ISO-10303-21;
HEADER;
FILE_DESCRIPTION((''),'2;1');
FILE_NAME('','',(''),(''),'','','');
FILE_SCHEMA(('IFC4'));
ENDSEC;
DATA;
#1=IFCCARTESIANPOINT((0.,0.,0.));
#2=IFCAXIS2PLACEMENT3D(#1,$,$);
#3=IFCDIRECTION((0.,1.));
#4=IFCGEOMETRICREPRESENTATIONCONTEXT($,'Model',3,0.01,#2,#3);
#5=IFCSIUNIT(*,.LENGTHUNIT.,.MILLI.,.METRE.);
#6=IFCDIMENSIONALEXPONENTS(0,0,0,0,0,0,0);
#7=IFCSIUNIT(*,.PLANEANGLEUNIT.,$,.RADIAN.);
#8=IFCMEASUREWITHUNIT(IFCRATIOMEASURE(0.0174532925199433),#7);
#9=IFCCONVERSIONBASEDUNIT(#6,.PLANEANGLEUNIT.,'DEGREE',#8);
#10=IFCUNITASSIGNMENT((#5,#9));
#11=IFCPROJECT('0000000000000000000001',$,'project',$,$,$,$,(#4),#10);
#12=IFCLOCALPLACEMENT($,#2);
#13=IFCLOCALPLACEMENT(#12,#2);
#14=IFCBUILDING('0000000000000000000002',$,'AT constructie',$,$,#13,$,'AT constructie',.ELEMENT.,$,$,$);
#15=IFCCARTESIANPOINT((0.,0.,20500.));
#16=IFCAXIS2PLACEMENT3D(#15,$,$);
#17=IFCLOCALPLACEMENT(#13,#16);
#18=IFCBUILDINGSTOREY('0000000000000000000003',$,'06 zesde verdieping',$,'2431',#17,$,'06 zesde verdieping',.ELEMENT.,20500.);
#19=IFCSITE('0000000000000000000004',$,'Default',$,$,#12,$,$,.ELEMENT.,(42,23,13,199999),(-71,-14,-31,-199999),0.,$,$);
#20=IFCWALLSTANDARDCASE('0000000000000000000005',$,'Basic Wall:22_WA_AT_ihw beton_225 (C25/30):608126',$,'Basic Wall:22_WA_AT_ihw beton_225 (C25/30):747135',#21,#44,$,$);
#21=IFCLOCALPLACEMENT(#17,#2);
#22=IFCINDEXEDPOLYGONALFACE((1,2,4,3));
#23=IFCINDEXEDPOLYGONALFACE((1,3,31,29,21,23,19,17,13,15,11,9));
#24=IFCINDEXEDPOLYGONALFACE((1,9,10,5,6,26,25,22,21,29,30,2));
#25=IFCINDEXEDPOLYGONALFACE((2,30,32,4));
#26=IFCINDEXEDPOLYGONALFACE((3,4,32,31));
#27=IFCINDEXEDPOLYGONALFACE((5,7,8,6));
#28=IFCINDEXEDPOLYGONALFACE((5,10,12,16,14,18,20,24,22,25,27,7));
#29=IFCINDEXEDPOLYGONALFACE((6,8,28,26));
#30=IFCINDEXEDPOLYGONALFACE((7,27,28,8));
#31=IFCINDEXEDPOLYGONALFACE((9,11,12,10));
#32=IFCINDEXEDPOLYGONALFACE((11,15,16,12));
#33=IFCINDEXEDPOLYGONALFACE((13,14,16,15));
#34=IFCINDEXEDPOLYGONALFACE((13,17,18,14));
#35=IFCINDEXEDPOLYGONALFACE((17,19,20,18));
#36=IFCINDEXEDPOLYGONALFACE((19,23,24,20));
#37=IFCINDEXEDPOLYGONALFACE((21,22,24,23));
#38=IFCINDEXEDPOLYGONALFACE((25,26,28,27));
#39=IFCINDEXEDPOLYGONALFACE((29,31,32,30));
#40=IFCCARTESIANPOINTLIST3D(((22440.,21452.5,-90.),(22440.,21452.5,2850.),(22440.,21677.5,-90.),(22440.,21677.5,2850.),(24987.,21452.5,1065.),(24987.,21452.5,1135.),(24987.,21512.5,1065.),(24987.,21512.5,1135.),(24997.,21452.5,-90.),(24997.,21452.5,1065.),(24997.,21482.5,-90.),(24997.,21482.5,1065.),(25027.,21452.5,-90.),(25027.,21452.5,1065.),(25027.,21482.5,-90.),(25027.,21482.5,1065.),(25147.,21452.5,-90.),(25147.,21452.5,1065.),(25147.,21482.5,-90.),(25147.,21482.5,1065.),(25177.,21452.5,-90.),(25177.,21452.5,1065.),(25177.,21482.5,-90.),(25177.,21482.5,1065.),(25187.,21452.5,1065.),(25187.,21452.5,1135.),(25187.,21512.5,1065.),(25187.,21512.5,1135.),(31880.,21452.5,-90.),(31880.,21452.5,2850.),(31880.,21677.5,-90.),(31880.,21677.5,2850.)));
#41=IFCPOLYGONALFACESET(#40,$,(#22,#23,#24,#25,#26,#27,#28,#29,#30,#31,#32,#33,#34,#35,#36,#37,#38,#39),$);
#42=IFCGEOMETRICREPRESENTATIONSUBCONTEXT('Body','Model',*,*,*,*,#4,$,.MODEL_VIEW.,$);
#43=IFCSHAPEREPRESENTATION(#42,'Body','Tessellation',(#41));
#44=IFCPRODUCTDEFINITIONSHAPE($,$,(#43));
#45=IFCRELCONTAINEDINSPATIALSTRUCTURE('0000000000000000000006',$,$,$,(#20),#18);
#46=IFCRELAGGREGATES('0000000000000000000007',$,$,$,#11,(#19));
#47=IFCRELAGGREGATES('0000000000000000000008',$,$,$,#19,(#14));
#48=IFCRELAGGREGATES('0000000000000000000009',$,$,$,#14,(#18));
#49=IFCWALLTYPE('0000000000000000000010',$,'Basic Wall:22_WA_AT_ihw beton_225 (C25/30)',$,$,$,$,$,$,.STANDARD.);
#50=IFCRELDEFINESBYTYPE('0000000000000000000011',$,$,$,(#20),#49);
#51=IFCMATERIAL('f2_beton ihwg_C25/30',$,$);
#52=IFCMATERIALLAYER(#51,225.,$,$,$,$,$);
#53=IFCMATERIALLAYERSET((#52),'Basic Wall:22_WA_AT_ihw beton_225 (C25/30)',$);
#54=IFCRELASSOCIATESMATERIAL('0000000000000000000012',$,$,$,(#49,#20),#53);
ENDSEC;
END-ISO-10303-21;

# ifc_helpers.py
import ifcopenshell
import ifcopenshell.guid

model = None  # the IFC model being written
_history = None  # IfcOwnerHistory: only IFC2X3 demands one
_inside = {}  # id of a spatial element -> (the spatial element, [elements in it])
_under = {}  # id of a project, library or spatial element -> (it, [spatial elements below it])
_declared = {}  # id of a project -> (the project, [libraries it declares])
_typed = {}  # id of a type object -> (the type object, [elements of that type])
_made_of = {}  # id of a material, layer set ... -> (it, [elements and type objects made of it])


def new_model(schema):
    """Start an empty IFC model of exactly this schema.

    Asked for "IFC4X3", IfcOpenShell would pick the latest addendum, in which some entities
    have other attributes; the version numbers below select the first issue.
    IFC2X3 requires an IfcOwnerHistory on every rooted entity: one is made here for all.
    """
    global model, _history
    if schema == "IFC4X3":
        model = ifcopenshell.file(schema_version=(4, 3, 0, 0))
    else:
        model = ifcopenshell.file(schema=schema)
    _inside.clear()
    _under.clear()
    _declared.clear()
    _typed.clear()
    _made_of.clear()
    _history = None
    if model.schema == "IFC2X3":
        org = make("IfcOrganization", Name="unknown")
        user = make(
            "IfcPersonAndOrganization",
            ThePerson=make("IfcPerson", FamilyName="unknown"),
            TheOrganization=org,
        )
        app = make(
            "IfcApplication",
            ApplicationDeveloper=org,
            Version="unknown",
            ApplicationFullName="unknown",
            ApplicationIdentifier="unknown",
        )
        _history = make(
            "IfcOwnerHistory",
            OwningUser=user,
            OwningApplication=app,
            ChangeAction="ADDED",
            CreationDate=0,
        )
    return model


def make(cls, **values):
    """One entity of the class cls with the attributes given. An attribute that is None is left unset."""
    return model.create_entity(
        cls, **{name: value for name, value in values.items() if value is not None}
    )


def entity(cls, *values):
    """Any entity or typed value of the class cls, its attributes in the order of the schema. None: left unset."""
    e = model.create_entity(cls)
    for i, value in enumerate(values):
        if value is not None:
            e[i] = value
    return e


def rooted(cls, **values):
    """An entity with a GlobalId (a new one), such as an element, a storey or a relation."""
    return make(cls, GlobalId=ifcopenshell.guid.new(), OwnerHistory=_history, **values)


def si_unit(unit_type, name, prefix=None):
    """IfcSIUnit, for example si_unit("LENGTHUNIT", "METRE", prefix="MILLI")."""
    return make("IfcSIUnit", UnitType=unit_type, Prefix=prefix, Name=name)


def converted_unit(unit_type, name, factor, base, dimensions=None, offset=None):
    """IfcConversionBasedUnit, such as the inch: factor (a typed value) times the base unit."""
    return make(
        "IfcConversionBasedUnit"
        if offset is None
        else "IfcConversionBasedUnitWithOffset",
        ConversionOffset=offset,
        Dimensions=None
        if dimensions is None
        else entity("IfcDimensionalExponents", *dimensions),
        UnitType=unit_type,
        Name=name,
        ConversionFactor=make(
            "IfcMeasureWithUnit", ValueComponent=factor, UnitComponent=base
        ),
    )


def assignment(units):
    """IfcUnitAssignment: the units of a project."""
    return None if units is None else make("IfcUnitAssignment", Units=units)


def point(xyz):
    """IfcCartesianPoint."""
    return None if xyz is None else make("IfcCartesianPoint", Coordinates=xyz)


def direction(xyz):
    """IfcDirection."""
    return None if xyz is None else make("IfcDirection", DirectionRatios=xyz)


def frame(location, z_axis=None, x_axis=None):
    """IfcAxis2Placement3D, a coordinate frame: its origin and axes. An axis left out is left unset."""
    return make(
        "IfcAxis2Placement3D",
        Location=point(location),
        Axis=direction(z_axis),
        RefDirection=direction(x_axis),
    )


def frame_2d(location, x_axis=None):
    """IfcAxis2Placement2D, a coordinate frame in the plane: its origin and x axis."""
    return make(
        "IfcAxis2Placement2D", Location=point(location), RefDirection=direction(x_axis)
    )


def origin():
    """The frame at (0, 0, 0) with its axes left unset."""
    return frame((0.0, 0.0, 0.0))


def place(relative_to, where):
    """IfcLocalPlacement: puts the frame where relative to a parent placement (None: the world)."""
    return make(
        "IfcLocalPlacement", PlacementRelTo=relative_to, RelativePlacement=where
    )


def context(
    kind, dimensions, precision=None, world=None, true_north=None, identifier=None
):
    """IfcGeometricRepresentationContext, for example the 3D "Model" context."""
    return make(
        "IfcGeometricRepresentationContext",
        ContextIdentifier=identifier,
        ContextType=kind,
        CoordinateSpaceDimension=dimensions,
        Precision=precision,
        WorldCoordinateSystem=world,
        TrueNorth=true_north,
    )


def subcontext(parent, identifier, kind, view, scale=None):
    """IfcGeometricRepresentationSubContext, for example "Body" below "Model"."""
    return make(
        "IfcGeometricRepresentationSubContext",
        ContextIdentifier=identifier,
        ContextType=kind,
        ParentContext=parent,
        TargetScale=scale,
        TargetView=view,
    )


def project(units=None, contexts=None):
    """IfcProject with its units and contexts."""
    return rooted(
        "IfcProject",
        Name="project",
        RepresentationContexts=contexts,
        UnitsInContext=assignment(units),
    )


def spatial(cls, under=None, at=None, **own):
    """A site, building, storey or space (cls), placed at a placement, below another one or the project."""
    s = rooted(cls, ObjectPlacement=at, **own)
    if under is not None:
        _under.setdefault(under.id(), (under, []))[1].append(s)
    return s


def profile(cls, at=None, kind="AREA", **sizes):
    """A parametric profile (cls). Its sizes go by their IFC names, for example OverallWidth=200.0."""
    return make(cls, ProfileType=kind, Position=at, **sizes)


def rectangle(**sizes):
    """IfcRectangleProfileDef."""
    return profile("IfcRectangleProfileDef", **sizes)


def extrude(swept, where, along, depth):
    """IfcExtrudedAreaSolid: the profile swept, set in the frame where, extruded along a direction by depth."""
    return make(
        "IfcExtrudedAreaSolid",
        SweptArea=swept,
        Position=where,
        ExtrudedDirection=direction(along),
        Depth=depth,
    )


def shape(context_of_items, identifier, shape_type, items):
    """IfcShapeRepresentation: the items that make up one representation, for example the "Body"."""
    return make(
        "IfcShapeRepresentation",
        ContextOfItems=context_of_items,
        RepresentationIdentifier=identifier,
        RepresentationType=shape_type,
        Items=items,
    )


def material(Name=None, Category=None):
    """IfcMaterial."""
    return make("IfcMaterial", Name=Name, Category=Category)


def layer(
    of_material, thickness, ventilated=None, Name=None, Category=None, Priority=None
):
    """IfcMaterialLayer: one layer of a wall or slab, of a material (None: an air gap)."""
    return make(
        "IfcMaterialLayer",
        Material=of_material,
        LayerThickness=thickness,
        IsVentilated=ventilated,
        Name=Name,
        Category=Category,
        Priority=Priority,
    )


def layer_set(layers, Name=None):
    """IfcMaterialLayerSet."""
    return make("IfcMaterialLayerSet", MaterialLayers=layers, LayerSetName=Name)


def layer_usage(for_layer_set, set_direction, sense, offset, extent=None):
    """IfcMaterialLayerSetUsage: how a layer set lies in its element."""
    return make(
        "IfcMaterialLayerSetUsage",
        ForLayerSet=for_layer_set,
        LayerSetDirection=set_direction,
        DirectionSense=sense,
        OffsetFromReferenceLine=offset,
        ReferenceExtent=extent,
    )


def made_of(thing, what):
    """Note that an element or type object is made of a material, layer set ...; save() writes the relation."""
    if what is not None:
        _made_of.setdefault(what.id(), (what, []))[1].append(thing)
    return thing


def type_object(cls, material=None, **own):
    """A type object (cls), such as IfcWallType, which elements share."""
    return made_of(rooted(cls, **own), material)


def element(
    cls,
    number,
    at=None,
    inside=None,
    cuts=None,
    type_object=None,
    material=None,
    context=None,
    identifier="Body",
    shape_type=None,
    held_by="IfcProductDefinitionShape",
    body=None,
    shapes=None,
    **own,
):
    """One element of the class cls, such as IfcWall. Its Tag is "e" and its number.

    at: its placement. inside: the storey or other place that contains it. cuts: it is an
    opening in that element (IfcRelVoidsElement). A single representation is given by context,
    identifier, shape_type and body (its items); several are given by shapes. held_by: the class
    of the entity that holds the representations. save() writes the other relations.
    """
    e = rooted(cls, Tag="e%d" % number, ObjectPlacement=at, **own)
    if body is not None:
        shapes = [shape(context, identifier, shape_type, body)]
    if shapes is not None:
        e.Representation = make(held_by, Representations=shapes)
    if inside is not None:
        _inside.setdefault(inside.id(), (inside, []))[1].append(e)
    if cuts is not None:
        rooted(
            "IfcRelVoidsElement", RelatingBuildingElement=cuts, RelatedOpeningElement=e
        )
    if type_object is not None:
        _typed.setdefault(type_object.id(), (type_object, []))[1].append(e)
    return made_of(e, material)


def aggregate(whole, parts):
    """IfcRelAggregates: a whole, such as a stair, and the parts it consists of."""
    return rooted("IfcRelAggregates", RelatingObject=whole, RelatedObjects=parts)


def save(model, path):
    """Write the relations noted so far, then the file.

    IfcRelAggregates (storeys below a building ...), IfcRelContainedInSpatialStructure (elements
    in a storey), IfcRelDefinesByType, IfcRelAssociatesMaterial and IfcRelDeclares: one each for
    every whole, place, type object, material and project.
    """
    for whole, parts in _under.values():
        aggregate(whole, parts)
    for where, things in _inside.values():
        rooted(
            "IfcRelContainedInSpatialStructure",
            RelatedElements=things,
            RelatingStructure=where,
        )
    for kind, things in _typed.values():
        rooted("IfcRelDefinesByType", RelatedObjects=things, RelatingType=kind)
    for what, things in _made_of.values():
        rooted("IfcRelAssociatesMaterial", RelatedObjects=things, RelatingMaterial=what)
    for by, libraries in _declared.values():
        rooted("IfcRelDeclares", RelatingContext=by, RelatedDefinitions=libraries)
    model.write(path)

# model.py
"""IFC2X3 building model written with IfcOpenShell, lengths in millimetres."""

from ifc_helpers import new_model, entity, si_unit, converted_unit, direction, frame, frame_2d, origin, place, context, subcontext, project, spatial, rectangle, extrude, material, layer, layer_set, layer_usage, type_object, element, save


model = new_model("IFC2X3")

# Units and contexts
model_context = context("Model", 3, precision=0.01, world=origin(), true_north=direction((0.0, 1.0)))
body_context = subcontext(model_context, "Body", "Model", "MODEL_VIEW")
ifc_project = project(units=[si_unit("LENGTHUNIT", "METRE", prefix="MILLI"), converted_unit("PLANEANGLEUNIT", "DEGREE", entity("IfcRatioMeasure", 0.0174532925199433), si_unit("PLANEANGLEUNIT", "RADIAN"), dimensions=[0, 0, 0, 0, 0, 0, 0])], contexts=[model_context])

# Site, building, storey
site_placement = place(None, origin())
site = spatial("IfcSite", under=ifc_project, at=site_placement, Name="Default", CompositionType="ELEMENT", RefLatitude=(42, 23, 13, 199999), RefLongitude=(-71, -14, -31, -199999), RefElevation=0.0)
building_placement = place(site_placement, origin())
building = spatial("IfcBuilding", under=site, at=building_placement, Name="AT constructie", LongName="AT constructie", CompositionType="ELEMENT")
storey_placement = place(building_placement, frame((0.0, 0.0, 20500.0)))
storey = spatial("IfcBuildingStorey", under=building, at=storey_placement, Name="06 zesde verdieping", ObjectType="2431", LongName="06 zesde verdieping", CompositionType="ELEMENT", Elevation=20500.0)

# Shared definitions
ifc_material_1 = material(Name="f2_beton ihwg_C25/30")
ifc_layer_1 = layer(ifc_material_1, 225.0)
ifc_layer_set_1 = layer_set([ifc_layer_1], Name="Basic Wall:22_WA_AT_ihw beton_225 (C25/30)")
wall_type_1 = type_object("IfcWallType", Name="Basic Wall:22_WA_AT_ihw beton_225 (C25/30)", PredefinedType="STANDARD", material=ifc_layer_set_1)

# Wall, openings
ifc_layer_usage_1 = layer_usage(ifc_layer_set_1, "AXIS2", "NEGATIVE", 112.5)
wall_1_placement = place(storey_placement, frame((22440.0, 21565.0, -90.0)))
wall_1 = element("IfcWallStandardCase", 1, at=wall_1_placement, inside=storey, type_object=wall_type_1, material=ifc_layer_usage_1, Name="Basic Wall:22_WA_AT_ihw beton_225 (C25/30):608126", ObjectType="Basic Wall:22_WA_AT_ihw beton_225 (C25/30):747135", context=body_context, shape_type="SweptSolid", body=[
    extrude(rectangle(XDim=9440.0, YDim=225.0, at=frame_2d((4720.0, 0.0), x_axis=(-1.0, 0.0))), origin(), (0.0, 0.0, 1.0), 2940.0),
])
opening_1_placement = place(wall_1_placement, origin())
element("IfcOpeningElement", 2, at=opening_1_placement, cuts=wall_1, ObjectType="Recess", context=body_context, shape_type="SweptSolid", body=[
    extrude(rectangle(XDim=1155.0, YDim=30.0, at=frame_2d((0.0, 0.0), x_axis=(1.0, 0.0))), frame((2572.0, -112.5, 577.5), z_axis=(0.0, 1.0, 0.0), x_axis=(0.0, 0.0, -1.0)), (0.0, 0.0, 1.0), 30.0),
])
opening_2_placement = place(wall_1_placement, origin())
element("IfcOpeningElement", 3, at=opening_2_placement, cuts=wall_1, ObjectType="Recess", context=body_context, shape_type="SweptSolid", body=[
    extrude(rectangle(XDim=1155.0, YDim=30.0, at=frame_2d((0.0, 0.0), x_axis=(1.0, 0.0))), frame((2722.0, -112.5, 577.5), z_axis=(0.0, 1.0, 0.0), x_axis=(0.0, 0.0, -1.0)), (0.0, 0.0, 1.0), 30.0),
])
opening_3_placement = place(wall_1_placement, origin())
element("IfcOpeningElement", 4, at=opening_3_placement, cuts=wall_1, ObjectType="Recess", context=body_context, shape_type="SweptSolid", body=[
    extrude(rectangle(XDim=70.0, YDim=200.0, at=frame_2d((0.0, 0.0), x_axis=(1.0, 0.0))), frame((2647.0, -112.5, 1190.0), z_axis=(0.0, 1.0, 0.0), x_axis=(0.0, 0.0, -1.0)), (0.0, 0.0, 1.0), 60.0),
])

save(model, "model.ifc")
